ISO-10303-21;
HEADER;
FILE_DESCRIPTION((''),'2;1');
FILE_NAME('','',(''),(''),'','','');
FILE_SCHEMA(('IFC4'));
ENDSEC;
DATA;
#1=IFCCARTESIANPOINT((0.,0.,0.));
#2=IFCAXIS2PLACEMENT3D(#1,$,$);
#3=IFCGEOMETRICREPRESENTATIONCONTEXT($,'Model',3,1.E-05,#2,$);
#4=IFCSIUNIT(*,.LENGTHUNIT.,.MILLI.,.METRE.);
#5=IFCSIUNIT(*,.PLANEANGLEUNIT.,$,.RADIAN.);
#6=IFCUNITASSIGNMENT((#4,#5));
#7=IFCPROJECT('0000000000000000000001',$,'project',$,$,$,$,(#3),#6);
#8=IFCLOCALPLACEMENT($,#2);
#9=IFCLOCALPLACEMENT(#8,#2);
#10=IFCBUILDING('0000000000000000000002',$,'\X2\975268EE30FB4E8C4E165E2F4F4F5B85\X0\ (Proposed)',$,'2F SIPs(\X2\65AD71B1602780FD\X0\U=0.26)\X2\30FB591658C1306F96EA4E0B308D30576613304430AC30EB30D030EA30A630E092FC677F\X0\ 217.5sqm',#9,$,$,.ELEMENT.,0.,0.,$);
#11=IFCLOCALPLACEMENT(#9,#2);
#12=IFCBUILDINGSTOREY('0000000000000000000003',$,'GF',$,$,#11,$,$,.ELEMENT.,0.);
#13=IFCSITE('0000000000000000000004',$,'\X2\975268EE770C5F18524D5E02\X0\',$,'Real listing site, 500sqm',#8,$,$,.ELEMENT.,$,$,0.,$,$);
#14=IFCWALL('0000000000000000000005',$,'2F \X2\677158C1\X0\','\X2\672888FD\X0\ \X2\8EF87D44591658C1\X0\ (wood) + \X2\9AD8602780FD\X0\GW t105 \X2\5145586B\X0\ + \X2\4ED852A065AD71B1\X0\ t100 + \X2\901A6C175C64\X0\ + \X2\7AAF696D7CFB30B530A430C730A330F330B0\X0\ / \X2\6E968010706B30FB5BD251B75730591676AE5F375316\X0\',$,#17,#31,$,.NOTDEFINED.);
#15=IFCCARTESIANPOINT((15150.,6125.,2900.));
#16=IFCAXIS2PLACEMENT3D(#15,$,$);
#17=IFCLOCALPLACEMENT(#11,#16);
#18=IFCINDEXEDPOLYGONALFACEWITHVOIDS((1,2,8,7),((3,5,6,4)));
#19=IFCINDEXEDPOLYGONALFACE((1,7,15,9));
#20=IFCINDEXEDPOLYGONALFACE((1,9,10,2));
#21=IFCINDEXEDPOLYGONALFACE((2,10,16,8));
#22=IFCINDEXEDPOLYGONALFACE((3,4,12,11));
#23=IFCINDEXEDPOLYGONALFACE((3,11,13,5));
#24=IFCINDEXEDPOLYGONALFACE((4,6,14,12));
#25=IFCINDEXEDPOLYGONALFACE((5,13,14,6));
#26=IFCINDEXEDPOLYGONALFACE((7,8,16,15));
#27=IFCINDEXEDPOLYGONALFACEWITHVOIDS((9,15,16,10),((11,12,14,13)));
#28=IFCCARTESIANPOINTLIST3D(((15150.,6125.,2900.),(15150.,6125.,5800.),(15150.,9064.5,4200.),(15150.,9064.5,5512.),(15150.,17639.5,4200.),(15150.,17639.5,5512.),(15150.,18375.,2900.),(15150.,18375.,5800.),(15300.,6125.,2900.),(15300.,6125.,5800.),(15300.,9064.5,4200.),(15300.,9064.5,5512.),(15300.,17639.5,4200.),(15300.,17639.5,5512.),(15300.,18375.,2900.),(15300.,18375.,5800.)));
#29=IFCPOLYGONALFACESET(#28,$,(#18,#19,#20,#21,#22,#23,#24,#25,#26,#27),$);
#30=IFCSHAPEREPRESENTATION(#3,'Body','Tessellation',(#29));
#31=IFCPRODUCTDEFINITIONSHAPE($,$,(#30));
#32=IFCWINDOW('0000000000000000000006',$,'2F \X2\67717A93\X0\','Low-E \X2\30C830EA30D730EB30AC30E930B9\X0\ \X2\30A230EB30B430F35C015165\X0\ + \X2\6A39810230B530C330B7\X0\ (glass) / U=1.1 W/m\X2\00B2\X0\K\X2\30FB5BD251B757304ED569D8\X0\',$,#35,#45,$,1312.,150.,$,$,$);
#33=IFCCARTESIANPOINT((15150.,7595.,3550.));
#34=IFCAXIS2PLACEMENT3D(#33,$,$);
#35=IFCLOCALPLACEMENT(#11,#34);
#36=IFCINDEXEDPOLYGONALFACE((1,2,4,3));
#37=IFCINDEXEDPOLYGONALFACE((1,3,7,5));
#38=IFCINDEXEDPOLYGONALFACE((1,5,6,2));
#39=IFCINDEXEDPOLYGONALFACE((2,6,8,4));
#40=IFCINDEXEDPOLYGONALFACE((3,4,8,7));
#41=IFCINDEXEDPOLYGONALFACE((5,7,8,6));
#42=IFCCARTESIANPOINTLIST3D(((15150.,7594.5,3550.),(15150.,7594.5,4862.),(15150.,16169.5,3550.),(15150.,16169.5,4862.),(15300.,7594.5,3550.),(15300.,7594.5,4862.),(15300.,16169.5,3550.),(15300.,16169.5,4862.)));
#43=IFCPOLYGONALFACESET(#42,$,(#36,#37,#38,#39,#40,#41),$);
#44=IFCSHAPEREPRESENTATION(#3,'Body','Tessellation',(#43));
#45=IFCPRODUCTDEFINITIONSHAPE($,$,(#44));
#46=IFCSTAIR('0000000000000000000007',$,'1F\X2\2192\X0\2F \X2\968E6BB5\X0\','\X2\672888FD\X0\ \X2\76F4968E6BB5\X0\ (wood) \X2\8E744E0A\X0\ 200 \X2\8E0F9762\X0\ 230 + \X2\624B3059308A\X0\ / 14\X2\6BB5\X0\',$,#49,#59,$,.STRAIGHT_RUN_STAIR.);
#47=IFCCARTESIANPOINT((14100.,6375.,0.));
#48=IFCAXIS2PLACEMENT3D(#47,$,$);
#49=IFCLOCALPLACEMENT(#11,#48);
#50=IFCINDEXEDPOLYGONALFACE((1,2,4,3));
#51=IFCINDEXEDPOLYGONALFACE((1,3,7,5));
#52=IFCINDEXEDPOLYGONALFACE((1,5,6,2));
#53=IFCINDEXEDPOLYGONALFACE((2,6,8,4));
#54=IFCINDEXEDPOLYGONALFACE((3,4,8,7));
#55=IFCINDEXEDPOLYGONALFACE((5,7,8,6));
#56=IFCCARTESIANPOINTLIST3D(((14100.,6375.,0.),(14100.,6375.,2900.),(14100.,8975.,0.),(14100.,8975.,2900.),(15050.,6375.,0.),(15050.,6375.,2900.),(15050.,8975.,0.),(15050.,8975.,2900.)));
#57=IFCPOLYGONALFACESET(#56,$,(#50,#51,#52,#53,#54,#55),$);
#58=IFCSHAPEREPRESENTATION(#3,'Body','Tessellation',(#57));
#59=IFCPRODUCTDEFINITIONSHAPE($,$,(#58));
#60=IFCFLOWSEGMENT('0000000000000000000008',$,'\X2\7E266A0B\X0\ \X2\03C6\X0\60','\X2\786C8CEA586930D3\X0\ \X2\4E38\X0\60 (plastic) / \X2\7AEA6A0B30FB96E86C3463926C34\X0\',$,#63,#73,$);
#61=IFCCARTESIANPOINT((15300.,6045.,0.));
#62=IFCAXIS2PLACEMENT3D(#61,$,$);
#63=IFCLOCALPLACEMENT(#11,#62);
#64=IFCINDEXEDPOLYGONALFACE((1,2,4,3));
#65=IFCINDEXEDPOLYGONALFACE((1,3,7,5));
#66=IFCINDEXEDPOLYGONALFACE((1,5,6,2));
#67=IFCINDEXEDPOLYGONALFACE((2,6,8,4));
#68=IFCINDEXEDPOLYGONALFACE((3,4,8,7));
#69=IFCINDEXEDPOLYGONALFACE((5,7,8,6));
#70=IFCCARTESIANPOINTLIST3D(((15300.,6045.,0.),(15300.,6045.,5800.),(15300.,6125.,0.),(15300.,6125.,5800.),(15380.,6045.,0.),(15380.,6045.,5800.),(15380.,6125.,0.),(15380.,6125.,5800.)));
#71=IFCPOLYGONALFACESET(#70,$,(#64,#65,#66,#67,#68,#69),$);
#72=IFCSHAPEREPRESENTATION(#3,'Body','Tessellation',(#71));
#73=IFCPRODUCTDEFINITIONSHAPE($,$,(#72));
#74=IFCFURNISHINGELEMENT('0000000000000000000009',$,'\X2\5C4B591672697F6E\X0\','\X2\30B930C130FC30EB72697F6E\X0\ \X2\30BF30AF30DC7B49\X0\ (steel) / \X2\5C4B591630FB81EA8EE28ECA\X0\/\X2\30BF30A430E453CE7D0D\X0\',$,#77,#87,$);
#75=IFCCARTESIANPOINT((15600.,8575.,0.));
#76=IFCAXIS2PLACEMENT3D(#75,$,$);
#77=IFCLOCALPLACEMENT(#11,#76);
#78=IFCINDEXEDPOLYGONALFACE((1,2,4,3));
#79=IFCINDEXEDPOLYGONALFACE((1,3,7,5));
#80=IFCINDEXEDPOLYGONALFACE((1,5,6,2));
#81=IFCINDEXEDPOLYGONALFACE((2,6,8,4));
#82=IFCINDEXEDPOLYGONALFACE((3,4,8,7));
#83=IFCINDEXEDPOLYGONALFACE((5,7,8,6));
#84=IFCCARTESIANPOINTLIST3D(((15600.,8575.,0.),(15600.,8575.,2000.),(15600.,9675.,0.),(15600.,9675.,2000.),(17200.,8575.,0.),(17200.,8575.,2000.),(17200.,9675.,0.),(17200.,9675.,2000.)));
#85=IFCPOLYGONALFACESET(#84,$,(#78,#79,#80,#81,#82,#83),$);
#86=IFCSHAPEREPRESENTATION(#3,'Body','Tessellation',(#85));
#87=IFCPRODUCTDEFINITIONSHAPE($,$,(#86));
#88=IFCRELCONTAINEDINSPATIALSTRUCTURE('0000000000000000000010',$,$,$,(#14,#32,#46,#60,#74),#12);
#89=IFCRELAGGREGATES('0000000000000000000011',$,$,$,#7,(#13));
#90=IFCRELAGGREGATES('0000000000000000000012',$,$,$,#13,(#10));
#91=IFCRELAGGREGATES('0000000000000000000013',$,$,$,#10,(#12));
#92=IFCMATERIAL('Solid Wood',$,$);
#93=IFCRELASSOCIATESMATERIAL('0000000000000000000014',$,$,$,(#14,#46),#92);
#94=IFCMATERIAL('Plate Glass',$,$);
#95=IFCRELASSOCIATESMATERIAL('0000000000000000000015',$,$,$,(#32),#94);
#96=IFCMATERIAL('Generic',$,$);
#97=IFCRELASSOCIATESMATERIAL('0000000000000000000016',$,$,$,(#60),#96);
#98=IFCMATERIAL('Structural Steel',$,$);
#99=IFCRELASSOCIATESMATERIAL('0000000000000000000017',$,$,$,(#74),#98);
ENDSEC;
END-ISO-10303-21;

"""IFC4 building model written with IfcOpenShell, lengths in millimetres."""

from ifc_helpers import new_model, si_unit, frame, frame_2d, origin, place, context, project, spatial, rectangle, extrude, material, element, fill, save


model = new_model("IFC4")

# Units and contexts
model_context = context("Model", 3, precision=1e-05, world=origin())
ifc_project = project(units=[si_unit("LENGTHUNIT", "METRE", prefix="MILLI"), si_unit("PLANEANGLEUNIT", "RADIAN")], contexts=[model_context])

# Site, building, storey
site_placement = place(None, origin())
site = spatial("IfcSite", under=ifc_project, at=site_placement, Name="青森県弘前市", ObjectType="Real listing site, 500sqm", CompositionType="ELEMENT", RefElevation=0.0)
building_placement = place(site_placement, origin())
building = spatial("IfcBuilding", under=site, at=building_placement, Name="青森・二世帯住宅 (Proposed)", ObjectType="2F SIPs(断熱性能U=0.26)・外壁は雪下ろし易いガルバリウム鋼板 217.5sqm", CompositionType="ELEMENT", ElevationOfRefHeight=0.0, ElevationOfTerrain=0.0)
storey_placement = place(building_placement, origin())
storey = spatial("IfcBuildingStorey", under=building, at=storey_placement, Name="GF", CompositionType="ELEMENT", Elevation=0.0)

# Shared definitions
ifc_material_1 = material(Name="Solid Wood")

# Wall, opening, window
ifc_material_2 = material(Name="Plate Glass")
wall_1_placement = place(storey_placement, frame((15150.0, 6125.0, 2900.0)))
wall_1 = element("IfcWall", 1, at=wall_1_placement, inside=storey, material=ifc_material_1, Name="2F 東壁", Description="木製 軸組外壁 (wood) + 高性能GW t105 充填 + 付加断熱 t100 + 通気層 + 窯業系サイディング / 準耐火・寒冷地外皮強化", PredefinedType="NOTDEFINED", context=model_context, shape_type="SweptSolid", body=[
    extrude(rectangle(XDim=150.0, YDim=12250.0, at=frame_2d((75.0, 6125.0))), frame((15150.0, 6125.0, 2900.0)), (0.0, 0.0, 1.0), 2900.0),
])
opening_1_placement = place(storey_placement, frame((15150.0, 7595.0, 3550.0)))
opening_1 = element("IfcOpeningElement", 2, at=opening_1_placement, cuts=wall_1, PredefinedType="NOTDEFINED", context=model_context, shape_type="SweptSolid", body=[
    extrude(rectangle(XDim=150.0, YDim=8575.0, at=frame_2d((75.0, 4287.0))), frame((15150.0, 7595.0, 3550.0)), (0.0, 0.0, 1.0), 1312.0),
])
window_1_placement = place(storey_placement, frame((15150.0, 7595.0, 3550.0)))
window_1 = element("IfcWindow", 3, at=window_1_placement, inside=storey, material=ifc_material_2, Name="2F 東窓", Description="Low-E トリプルガラス アルゴン封入 + 樹脂サッシ (glass) / U=1.1 W/m²K・寒冷地仕様", OverallHeight=1312.0, OverallWidth=150.0, context=model_context, shape_type="SweptSolid", body=[
    extrude(rectangle(XDim=150.0, YDim=8575.0, at=frame_2d((75.0, 4287.0))), frame((15150.0, 7595.0, 3550.0)), (0.0, 0.0, 1.0), 1312.0),
])
fill(opening_1, window_1)

# Stair
stair_placement = place(storey_placement, frame((14100.0, 6375.0, 0.0)))
element("IfcStair", 4, at=stair_placement, inside=storey, material=ifc_material_1, Name="1F→2F 階段", Description="木製 直階段 (wood) 蹴上 200 踏面 230 + 手すり / 14段", PredefinedType="STRAIGHT_RUN_STAIR", context=model_context, shape_type="SweptSolid", body=[
    extrude(rectangle(XDim=950.0, YDim=2600.0, at=frame_2d((475.0, 1300.0))), frame((14100.0, 6375.0, 0.0)), (0.0, 0.0, 1.0), 2900.0),
])

# Flow segment
ifc_material_3 = material(Name="Generic")
flow_segment_placement = place(storey_placement, frame((15300.0, 6045.0, 0.0)))
element("IfcFlowSegment", 5, at=flow_segment_placement, inside=storey, material=ifc_material_3, Name="縦樋 φ60", Description="硬質塩ビ 丸60 (plastic) / 竪樋・雨水排水", context=model_context, shape_type="SweptSolid", body=[
    extrude(rectangle(XDim=80.0, YDim=80.0, at=frame_2d((40.0, 40.0))), frame((15300.0, 6045.0, 0.0)), (0.0, 0.0, 1.0), 5800.0),
])

# Furnishing element
ifc_material_4 = material(Name="Structural Steel")
furnishing_placement = place(storey_placement, frame((15600.0, 8575.0, 0.0)))
element("IfcFurnishingElement", 6, at=furnishing_placement, inside=storey, material=ifc_material_4, Name="屋外物置", Description="スチール物置 タクボ等 (steel) / 屋外・自転車/タイヤ収納", context=model_context, shape_type="SweptSolid", body=[
    extrude(rectangle(XDim=1600.0, YDim=1100.0, at=frame_2d((800.0, 550.0))), frame((15600.0, 8575.0, 0.0)), (0.0, 0.0, 1.0), 2000.0),
])

save(model, "model.ifc")
